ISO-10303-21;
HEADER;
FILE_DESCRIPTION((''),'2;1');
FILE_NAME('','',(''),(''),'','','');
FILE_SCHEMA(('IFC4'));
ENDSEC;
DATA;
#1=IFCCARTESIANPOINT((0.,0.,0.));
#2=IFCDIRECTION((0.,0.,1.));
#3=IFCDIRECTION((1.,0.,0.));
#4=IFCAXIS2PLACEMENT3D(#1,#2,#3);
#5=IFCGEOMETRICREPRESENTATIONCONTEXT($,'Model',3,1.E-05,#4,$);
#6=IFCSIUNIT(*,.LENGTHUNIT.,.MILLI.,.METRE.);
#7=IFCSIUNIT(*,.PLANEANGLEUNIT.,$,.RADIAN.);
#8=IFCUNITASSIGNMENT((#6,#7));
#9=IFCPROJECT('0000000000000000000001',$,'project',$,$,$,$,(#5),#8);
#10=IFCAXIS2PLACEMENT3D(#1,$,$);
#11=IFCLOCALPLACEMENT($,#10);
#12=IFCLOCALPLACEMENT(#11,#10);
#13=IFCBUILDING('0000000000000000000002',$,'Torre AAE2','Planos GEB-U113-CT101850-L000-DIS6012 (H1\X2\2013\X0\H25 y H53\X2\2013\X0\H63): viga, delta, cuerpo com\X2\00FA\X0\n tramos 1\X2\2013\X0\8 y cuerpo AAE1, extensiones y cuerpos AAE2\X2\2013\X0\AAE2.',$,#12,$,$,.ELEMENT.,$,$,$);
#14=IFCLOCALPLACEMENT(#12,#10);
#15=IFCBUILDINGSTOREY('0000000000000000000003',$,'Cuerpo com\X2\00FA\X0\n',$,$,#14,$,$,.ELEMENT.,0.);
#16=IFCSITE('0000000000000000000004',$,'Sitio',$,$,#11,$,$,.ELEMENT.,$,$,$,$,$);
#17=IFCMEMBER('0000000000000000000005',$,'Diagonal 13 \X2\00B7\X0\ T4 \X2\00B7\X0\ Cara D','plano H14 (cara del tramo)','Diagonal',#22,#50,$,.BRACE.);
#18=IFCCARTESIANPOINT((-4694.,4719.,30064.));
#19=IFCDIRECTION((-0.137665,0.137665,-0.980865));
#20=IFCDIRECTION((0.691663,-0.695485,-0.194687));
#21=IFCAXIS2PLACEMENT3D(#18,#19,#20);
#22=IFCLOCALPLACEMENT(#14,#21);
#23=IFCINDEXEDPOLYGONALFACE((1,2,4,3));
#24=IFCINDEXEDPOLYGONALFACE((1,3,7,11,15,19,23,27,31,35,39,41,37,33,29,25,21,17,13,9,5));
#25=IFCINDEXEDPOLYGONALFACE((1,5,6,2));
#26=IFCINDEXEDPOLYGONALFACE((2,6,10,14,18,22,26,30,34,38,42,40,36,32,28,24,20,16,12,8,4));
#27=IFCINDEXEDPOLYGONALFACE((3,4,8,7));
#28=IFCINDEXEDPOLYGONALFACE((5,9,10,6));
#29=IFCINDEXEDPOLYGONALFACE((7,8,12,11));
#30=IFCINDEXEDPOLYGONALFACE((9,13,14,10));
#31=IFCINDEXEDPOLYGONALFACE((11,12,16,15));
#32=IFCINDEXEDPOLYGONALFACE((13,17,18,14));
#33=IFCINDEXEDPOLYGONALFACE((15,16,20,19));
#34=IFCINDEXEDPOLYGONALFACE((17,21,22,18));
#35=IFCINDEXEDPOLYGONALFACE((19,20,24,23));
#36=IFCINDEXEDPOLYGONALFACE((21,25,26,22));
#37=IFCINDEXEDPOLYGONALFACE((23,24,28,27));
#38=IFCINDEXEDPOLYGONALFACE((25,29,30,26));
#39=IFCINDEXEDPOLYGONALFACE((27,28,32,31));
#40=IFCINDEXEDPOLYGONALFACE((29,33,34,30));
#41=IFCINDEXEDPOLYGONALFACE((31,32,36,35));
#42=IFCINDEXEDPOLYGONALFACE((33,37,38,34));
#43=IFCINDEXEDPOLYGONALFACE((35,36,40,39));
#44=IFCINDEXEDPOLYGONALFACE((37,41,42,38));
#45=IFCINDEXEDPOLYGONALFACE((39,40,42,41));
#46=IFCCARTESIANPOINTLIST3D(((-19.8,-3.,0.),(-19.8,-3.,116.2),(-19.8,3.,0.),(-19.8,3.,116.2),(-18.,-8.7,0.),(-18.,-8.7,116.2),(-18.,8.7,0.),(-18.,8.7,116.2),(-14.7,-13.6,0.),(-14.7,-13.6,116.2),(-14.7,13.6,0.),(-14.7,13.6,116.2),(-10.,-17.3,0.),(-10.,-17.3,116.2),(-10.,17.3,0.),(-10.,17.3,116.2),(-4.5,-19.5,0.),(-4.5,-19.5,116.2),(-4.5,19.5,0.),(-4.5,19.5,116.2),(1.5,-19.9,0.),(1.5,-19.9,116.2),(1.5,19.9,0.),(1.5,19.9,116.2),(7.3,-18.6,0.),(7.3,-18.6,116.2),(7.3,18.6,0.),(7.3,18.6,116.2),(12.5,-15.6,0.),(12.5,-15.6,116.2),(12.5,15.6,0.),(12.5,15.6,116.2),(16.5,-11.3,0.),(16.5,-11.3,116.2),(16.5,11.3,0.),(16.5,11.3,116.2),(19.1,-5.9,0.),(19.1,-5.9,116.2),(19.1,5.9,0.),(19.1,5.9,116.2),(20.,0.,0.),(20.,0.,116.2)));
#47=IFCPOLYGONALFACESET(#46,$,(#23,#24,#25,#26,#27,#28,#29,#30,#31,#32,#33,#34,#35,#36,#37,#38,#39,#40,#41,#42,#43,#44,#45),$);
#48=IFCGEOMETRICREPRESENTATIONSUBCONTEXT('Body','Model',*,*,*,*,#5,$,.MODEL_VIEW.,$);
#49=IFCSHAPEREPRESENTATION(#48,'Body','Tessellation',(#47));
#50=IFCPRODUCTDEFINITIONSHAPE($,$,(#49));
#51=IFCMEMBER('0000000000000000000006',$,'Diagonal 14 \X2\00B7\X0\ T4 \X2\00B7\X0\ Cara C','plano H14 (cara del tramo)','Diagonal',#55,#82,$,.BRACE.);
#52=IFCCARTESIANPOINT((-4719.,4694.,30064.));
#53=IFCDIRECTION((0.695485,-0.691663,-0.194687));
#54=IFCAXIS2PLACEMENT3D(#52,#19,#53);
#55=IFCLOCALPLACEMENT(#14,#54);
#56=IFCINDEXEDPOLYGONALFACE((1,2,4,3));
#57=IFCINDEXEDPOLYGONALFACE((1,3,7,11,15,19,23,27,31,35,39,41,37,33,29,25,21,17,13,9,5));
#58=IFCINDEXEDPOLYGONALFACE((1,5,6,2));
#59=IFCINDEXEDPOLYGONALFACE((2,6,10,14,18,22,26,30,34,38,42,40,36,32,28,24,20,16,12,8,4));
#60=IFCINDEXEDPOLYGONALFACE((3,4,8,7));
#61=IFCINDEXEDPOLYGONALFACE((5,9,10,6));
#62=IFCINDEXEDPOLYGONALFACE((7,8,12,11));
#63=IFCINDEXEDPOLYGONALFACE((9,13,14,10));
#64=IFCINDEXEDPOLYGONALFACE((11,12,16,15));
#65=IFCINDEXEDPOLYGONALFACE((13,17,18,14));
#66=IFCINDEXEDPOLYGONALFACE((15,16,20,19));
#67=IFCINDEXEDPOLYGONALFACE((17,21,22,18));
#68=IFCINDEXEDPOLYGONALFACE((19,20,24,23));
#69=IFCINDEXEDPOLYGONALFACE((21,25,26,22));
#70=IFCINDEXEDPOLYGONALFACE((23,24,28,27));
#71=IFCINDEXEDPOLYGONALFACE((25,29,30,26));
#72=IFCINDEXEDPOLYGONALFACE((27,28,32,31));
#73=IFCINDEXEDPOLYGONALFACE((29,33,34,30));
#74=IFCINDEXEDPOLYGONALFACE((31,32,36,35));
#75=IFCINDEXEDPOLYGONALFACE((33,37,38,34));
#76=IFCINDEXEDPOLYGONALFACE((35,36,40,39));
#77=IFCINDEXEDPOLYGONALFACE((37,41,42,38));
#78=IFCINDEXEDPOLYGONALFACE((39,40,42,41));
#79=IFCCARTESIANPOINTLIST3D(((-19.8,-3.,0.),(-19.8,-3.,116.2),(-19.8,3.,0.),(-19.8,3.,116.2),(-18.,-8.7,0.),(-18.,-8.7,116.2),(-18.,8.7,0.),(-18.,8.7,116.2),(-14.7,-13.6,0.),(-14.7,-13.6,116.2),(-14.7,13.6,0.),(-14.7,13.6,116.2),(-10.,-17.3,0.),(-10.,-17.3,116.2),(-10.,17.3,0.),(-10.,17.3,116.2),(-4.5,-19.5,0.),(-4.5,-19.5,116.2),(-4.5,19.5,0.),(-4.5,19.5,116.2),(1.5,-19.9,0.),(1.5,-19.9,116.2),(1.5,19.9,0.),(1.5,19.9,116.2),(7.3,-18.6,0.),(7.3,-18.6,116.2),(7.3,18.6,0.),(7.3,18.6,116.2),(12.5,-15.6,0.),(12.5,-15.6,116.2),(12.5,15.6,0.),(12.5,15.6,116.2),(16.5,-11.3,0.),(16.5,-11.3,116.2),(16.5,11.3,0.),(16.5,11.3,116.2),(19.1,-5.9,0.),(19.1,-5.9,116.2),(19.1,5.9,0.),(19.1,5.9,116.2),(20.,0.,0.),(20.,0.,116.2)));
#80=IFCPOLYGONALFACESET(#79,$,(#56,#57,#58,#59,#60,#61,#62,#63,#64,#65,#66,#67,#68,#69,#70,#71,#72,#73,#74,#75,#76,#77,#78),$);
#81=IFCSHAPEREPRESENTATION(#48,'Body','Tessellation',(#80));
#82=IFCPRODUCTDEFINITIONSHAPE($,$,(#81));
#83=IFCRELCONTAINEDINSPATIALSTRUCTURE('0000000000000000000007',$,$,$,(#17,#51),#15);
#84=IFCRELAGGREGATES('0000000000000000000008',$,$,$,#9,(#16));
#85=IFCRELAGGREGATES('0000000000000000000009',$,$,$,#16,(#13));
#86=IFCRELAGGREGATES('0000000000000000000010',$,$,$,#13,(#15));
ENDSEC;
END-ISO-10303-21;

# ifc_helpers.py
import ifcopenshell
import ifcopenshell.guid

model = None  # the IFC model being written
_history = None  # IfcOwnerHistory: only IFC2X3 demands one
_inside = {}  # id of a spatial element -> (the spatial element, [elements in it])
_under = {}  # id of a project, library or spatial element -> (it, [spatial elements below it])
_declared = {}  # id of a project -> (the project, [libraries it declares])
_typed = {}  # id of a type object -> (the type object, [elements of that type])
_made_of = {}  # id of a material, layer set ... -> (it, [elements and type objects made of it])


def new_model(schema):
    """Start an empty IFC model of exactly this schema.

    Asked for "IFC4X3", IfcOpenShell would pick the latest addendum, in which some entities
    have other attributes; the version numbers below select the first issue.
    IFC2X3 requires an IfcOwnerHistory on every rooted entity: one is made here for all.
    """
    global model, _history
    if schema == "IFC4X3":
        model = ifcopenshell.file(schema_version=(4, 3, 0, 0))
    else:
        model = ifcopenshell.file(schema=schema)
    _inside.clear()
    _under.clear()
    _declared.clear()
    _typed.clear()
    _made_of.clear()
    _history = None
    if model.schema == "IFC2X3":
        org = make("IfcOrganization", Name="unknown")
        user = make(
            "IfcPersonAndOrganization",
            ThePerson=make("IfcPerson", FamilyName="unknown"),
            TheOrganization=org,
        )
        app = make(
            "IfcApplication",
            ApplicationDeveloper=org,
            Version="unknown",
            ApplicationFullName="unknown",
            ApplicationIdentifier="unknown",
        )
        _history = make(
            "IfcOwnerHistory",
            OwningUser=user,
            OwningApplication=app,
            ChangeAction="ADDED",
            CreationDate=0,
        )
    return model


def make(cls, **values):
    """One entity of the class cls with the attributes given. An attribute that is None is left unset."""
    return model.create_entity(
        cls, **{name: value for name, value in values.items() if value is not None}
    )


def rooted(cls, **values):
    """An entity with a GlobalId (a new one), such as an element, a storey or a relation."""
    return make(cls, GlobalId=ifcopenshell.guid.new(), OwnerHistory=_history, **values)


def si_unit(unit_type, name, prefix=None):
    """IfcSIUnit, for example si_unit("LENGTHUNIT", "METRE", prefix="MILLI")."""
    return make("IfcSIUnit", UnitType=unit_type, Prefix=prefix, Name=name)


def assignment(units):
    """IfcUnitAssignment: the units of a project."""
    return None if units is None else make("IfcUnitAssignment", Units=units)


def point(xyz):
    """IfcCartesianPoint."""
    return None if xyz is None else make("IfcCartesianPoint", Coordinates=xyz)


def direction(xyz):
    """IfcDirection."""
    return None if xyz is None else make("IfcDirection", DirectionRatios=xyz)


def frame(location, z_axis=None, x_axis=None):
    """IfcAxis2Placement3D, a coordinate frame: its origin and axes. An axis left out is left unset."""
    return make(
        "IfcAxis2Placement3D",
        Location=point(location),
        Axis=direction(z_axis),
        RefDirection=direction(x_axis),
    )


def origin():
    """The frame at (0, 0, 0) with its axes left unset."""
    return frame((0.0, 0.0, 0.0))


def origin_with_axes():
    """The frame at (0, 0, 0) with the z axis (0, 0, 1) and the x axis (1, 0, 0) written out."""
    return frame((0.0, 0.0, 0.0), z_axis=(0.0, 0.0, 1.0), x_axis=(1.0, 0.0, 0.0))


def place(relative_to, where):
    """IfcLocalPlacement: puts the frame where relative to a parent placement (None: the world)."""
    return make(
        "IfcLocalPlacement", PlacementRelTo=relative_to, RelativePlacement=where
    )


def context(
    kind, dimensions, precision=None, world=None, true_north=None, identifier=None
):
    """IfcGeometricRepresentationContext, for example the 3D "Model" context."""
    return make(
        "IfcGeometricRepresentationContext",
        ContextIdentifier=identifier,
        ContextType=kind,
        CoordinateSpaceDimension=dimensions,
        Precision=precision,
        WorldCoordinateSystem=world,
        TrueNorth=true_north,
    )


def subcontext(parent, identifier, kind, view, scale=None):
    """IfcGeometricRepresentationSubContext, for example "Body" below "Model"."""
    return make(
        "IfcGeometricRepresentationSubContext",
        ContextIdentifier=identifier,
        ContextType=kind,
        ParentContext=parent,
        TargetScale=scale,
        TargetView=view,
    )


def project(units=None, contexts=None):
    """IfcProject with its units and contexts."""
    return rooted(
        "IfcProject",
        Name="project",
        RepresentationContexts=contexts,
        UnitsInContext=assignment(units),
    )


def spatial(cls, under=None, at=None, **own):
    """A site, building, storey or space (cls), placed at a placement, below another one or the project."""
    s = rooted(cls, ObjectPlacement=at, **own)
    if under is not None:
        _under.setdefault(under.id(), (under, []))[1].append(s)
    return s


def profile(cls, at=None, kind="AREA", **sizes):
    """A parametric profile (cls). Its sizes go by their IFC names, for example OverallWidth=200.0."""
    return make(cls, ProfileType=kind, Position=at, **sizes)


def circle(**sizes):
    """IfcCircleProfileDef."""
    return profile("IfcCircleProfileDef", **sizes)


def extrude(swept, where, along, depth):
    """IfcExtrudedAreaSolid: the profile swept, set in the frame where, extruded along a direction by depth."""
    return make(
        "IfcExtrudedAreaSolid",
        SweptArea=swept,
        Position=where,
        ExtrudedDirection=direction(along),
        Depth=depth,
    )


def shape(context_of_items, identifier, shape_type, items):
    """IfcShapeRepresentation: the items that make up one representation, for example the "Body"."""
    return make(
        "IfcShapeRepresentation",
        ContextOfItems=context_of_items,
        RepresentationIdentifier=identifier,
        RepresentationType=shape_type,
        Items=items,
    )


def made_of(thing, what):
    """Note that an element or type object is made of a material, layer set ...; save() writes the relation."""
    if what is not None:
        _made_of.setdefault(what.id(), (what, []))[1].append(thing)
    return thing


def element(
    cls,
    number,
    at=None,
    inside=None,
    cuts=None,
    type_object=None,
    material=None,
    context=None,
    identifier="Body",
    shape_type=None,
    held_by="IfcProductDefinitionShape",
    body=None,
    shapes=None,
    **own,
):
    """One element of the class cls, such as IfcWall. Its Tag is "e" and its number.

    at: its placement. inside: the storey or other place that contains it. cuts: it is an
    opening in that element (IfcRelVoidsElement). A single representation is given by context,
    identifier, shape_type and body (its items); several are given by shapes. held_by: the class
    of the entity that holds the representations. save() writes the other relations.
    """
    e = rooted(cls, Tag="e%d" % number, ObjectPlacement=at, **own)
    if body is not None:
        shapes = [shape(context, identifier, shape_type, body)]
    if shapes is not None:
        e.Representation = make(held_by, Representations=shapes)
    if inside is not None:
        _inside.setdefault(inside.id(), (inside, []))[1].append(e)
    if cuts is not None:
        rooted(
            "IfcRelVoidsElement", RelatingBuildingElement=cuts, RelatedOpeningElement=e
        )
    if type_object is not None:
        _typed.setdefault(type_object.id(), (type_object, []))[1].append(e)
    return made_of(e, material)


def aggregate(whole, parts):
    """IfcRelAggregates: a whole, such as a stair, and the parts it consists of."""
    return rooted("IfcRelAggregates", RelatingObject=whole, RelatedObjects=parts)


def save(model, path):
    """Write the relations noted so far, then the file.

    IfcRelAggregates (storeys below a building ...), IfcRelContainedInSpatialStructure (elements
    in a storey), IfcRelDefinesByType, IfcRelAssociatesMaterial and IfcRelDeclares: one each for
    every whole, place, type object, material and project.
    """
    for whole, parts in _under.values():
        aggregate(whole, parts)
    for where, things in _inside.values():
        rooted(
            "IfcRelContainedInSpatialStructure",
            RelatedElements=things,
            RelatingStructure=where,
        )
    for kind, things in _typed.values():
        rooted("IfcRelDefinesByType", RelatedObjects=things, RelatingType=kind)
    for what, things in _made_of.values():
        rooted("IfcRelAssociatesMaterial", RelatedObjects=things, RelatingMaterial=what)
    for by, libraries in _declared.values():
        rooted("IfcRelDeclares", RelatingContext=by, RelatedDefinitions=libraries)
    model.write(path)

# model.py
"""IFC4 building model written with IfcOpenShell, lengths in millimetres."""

from ifc_helpers import new_model, si_unit, frame, origin, origin_with_axes, place, context, subcontext, project, spatial, circle, extrude, element, save


model = new_model("IFC4")

# Units and contexts
model_context = context("Model", 3, precision=1e-05, world=origin_with_axes())
body_context = subcontext(model_context, "Body", "Model", "MODEL_VIEW")
ifc_project = project(units=[si_unit("LENGTHUNIT", "METRE", prefix="MILLI"), si_unit("PLANEANGLEUNIT", "RADIAN")], contexts=[model_context])

# Site, building, storey
site_placement = place(None, origin())
site = spatial("IfcSite", under=ifc_project, at=site_placement, Name="Sitio", CompositionType="ELEMENT")
building_placement = place(site_placement, origin())
building = spatial("IfcBuilding", under=site, at=building_placement, Name="Torre AAE2", Description="Planos GEB-U113-CT101850-L000-DIS6012 (H1–H25 y H53–H63): viga, delta, cuerpo común tramos 1–8 y cuerpo AAE1, extensiones y cuerpos AAE2–AAE2.", CompositionType="ELEMENT")
storey_placement = place(building_placement, origin())
storey = spatial("IfcBuildingStorey", under=building, at=storey_placement, Name="Cuerpo común", CompositionType="ELEMENT", Elevation=0.0)

# Members
for number, where, z_axis, x_axis, name in (
    (1, (-4694.0, 4719.0, 30064.0), (-0.137665, 0.137665, -0.980865), (0.691663, -0.695485, -0.194687), "Diagonal 13 · T4 · Cara D"),
    (2, (-4719.0, 4694.0, 30064.0), (-0.137665, 0.137665, -0.980865), (0.695485, -0.691663, -0.194687), "Diagonal 14 · T4 · Cara C"),
):
    element("IfcMember", number, at=place(storey_placement, frame(where, z_axis=z_axis, x_axis=x_axis)), inside=storey, Name=name, Description="plano H14 (cara del tramo)", ObjectType="Diagonal", PredefinedType="BRACE", context=body_context, shape_type="SweptSolid", body=[
        extrude(circle(Radius=20.0), None, (0.0, 0.0, 1.0), 116.2),
    ])

save(model, "model.ifc")
